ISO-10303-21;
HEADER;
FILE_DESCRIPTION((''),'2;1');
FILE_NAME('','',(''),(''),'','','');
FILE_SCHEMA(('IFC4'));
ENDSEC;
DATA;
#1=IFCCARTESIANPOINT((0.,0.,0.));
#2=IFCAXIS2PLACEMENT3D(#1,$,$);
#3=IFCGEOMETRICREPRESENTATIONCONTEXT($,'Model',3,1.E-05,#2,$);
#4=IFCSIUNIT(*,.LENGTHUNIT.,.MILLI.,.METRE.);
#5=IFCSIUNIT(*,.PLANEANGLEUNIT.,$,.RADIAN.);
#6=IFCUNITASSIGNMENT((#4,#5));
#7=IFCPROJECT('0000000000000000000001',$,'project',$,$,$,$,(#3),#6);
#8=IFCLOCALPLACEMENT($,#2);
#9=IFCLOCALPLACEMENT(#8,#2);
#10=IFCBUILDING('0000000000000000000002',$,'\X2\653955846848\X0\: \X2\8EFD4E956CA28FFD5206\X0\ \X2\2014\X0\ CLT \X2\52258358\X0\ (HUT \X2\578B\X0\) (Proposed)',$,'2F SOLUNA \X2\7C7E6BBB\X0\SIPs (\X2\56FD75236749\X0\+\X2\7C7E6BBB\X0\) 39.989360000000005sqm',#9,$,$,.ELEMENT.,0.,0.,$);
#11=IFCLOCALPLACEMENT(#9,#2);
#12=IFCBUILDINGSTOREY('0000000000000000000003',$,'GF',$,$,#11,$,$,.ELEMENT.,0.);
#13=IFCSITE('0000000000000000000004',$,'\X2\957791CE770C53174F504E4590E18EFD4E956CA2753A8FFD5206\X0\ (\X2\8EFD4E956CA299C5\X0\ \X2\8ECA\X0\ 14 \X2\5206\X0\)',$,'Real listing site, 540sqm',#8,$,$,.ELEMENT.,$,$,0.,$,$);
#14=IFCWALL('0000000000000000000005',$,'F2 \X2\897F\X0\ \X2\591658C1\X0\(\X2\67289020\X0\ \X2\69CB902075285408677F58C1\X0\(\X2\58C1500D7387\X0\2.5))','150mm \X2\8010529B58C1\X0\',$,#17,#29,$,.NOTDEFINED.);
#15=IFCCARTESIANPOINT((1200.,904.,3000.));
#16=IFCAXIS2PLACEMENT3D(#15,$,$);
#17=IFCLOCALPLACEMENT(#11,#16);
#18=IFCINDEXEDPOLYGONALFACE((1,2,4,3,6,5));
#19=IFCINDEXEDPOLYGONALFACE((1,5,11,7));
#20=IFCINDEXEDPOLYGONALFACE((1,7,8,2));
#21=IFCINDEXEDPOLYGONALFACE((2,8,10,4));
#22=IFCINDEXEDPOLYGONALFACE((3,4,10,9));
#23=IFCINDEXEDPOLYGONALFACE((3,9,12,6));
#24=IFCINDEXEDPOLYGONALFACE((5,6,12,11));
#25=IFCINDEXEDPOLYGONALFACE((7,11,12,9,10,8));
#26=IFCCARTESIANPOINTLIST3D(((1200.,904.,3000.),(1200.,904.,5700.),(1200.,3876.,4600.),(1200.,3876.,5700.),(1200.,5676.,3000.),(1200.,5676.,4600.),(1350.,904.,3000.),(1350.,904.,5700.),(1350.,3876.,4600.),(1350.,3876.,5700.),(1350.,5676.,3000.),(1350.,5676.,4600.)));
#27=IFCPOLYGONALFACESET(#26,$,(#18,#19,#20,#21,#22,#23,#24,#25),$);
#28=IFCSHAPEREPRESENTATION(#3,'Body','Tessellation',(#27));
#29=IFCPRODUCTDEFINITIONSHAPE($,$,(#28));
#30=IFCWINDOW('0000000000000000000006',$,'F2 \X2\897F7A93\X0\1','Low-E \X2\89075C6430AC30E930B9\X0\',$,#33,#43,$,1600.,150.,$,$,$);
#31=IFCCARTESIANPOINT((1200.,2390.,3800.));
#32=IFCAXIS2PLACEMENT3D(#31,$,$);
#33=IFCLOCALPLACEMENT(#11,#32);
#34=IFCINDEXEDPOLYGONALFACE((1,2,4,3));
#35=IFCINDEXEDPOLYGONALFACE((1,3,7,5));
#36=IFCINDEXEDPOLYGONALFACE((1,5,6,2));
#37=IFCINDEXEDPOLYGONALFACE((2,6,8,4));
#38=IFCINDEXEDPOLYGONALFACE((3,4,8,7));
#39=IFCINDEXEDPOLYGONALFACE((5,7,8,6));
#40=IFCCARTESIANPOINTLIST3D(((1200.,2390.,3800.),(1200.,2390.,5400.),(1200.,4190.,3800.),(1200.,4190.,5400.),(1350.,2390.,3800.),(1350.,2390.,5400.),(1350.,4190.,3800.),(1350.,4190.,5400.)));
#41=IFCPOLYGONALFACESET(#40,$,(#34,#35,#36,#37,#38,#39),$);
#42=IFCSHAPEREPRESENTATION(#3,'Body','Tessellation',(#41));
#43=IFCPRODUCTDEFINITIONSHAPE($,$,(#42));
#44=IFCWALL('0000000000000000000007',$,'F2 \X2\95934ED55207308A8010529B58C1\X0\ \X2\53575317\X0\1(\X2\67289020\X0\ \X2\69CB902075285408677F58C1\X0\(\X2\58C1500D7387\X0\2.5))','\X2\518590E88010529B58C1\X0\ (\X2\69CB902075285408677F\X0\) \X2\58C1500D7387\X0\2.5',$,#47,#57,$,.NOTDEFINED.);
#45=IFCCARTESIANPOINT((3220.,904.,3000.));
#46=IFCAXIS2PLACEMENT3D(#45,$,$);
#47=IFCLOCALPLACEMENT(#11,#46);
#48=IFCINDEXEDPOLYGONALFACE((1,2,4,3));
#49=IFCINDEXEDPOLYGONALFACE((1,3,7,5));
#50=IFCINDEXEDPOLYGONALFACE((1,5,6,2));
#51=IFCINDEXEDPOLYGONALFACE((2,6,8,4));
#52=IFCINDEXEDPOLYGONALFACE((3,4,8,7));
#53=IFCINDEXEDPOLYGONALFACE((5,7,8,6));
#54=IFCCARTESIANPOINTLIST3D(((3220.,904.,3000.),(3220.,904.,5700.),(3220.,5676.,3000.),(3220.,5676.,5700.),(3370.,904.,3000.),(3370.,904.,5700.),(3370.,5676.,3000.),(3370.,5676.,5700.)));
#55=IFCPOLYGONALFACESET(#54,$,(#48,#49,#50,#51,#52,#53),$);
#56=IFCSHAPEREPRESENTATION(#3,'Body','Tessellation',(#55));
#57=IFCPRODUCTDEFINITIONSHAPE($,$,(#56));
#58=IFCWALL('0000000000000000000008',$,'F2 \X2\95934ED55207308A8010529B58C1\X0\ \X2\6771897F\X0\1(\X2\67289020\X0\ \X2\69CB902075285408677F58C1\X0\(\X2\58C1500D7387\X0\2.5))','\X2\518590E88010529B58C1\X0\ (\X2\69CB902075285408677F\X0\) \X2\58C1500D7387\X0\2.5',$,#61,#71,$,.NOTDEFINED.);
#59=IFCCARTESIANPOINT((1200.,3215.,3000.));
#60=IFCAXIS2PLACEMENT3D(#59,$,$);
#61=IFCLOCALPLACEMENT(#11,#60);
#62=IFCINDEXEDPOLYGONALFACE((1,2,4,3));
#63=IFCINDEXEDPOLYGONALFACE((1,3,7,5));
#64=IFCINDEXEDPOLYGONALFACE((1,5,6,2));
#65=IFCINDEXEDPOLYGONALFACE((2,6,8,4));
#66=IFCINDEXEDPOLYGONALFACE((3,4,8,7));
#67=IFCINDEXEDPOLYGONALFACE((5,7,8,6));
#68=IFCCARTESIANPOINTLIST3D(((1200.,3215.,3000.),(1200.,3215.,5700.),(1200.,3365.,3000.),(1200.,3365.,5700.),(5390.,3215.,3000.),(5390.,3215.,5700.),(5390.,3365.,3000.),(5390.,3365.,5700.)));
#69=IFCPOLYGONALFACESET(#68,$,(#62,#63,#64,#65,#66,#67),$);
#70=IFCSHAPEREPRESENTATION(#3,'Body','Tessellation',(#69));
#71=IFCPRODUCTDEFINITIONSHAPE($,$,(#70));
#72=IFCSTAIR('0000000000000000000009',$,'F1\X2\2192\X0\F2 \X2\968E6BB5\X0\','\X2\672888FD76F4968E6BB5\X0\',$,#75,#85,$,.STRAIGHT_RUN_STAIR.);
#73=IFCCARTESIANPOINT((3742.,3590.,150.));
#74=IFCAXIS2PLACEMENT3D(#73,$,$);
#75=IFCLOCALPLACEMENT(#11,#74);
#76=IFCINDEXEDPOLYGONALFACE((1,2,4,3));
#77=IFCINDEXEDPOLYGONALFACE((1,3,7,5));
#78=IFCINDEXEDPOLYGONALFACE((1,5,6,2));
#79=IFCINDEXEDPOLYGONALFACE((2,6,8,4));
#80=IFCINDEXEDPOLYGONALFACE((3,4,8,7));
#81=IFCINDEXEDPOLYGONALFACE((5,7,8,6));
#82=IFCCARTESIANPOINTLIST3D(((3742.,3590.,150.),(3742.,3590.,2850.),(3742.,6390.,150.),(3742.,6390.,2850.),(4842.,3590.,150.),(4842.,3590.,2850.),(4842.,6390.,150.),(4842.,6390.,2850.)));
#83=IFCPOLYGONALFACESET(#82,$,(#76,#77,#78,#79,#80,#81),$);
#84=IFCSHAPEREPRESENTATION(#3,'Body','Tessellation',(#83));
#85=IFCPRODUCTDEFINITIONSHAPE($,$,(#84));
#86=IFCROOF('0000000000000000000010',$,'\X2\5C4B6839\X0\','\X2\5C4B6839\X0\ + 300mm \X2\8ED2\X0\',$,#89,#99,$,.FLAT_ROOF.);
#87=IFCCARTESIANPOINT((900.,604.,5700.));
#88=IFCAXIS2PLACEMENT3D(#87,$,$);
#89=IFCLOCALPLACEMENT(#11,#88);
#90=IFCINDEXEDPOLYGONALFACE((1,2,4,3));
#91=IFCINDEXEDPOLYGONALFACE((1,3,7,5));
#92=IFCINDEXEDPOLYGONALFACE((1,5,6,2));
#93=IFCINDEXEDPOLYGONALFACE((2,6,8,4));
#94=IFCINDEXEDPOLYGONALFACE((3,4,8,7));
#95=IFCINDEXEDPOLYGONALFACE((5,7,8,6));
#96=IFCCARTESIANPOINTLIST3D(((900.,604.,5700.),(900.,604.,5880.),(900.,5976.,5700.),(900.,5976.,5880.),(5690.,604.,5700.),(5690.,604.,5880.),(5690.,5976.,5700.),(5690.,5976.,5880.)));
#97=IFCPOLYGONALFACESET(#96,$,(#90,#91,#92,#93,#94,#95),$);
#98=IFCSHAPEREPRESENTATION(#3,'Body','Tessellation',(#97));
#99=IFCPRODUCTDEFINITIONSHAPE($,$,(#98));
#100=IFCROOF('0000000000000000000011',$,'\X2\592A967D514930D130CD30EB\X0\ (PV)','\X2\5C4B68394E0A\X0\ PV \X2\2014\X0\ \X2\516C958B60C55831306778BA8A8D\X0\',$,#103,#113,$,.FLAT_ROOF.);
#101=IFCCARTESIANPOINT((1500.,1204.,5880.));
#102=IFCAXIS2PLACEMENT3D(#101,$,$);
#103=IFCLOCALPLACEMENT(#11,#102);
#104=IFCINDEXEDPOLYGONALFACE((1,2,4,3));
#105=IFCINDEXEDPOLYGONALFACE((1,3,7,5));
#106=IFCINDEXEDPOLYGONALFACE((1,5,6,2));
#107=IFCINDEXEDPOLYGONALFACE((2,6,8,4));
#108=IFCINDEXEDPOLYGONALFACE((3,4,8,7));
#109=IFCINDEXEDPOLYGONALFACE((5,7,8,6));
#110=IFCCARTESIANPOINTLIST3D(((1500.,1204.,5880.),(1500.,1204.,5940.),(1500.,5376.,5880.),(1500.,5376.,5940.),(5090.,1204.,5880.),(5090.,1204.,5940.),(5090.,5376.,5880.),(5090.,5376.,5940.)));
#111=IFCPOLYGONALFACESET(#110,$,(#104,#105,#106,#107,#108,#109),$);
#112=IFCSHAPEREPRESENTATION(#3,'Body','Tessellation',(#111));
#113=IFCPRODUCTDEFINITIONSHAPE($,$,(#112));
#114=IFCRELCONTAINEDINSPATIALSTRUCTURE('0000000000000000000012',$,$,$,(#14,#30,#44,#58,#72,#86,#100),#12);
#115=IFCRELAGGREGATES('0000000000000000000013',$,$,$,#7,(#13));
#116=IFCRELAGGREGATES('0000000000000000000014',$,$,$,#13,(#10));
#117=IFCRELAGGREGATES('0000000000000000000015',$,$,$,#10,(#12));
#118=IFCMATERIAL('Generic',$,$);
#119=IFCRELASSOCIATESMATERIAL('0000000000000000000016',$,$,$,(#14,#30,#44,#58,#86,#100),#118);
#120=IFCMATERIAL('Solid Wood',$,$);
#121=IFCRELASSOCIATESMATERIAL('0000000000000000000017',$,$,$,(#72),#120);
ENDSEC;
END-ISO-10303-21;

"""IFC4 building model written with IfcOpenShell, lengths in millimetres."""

from ifc_helpers import new_model, si_unit, frame, frame_2d, origin, place, context, project, spatial, rectangle, extrude, material, element, fill, save


model = new_model("IFC4")

# Units and contexts
model_context = context("Model", 3, precision=1e-05, world=origin())
ifc_project = project(units=[si_unit("LENGTHUNIT", "METRE", prefix="MILLI"), si_unit("PLANEANGLEUNIT", "RADIAN")], contexts=[model_context])

# Site, building, storey
site_placement = place(None, origin())
site = spatial("IfcSite", under=ifc_project, at=site_placement, Name="長野県北佐久郡軽井沢町追分 (軽井沢駅 車 14 分)", ObjectType="Real listing site, 540sqm", CompositionType="ELEMENT", RefElevation=0.0)
building_placement = place(site_placement, origin())
building = spatial("IfcBuilding", under=site, at=building_placement, Name="改善案: 軽井沢追分 — CLT 別荘 (HUT 型) (Proposed)", ObjectType="2F SOLUNA 籾殻SIPs (国産杉+籾殻) 39.989360000000005sqm", CompositionType="ELEMENT", ElevationOfRefHeight=0.0, ElevationOfTerrain=0.0)
storey_placement = place(building_placement, origin())
storey = spatial("IfcBuildingStorey", under=building, at=storey_placement, Name="GF", CompositionType="ELEMENT", Elevation=0.0)

# Shared definitions
ifc_material_1 = material(Name="Generic")

# Shared definitions
ifc_material_2 = material(Name="Solid Wood")

# Wall, opening, window
wall_1_placement = place(storey_placement, frame((1200.0, 904.0, 3000.0)))
wall_1 = element("IfcWall", 1, at=wall_1_placement, inside=storey, material=ifc_material_1, Name="F2 西 外壁(木造 構造用合板壁(壁倍率2.5))", Description="150mm 耐力壁", PredefinedType="NOTDEFINED", context=model_context, shape_type="SweptSolid", body=[
    extrude(rectangle(XDim=150.0, YDim=4772.0, at=frame_2d((75.0, 2386.0))), frame((1200.0, 904.0, 3000.0)), (0.0, 0.0, 1.0), 2700.0),
])
opening_1_placement = place(storey_placement, frame((1200.0, 2390.0, 3800.0)))
opening_1 = element("IfcOpeningElement", 2, at=opening_1_placement, cuts=wall_1, PredefinedType="NOTDEFINED", context=model_context, shape_type="SweptSolid", body=[
    extrude(rectangle(XDim=150.0, YDim=1800.0, at=frame_2d((75.0, 900.0))), frame((1200.0, 2390.0, 3800.0)), (0.0, 0.0, 1.0), 1600.0),
])
window_1_placement = place(storey_placement, frame((1200.0, 2390.0, 3800.0)))
window_1 = element("IfcWindow", 3, at=window_1_placement, inside=storey, material=ifc_material_1, Name="F2 西窓1", Description="Low-E 複層ガラス", OverallHeight=1600.0, OverallWidth=150.0, context=model_context, shape_type="SweptSolid", body=[
    extrude(rectangle(XDim=150.0, YDim=1800.0, at=frame_2d((75.0, 900.0))), frame((1200.0, 2390.0, 3800.0)), (0.0, 0.0, 1.0), 1600.0),
])
fill(opening_1, window_1)

# Walls
wall_2_placement = place(storey_placement, frame((3220.0, 904.0, 3000.0)))
element("IfcWall", 4, at=wall_2_placement, inside=storey, material=ifc_material_1, Name="F2 間仕切り耐力壁 南北1(木造 構造用合板壁(壁倍率2.5))", Description="内部耐力壁 (構造用合板) 壁倍率2.5", PredefinedType="NOTDEFINED", context=model_context, shape_type="SweptSolid", body=[
    extrude(rectangle(XDim=150.0, YDim=4772.0, at=frame_2d((75.0, 2386.0))), frame((3220.0, 904.0, 3000.0)), (0.0, 0.0, 1.0), 2700.0),
])
wall_3_placement = place(storey_placement, frame((1200.0, 3215.0, 3000.0)))
element("IfcWall", 5, at=wall_3_placement, inside=storey, material=ifc_material_1, Name="F2 間仕切り耐力壁 東西1(木造 構造用合板壁(壁倍率2.5))", Description="内部耐力壁 (構造用合板) 壁倍率2.5", PredefinedType="NOTDEFINED", context=model_context, shape_type="SweptSolid", body=[
    extrude(rectangle(XDim=4190.0, YDim=150.0, at=frame_2d((2095.0, 75.0))), frame((1200.0, 3215.0, 3000.0)), (0.0, 0.0, 1.0), 2700.0),
])

# Stair
stair_placement = place(storey_placement, frame((3742.0, 3590.0, 150.0)))
element("IfcStair", 6, at=stair_placement, inside=storey, material=ifc_material_2, Name="F1→F2 階段", Description="木製直階段", PredefinedType="STRAIGHT_RUN_STAIR", context=model_context, shape_type="SweptSolid", body=[
    extrude(rectangle(XDim=1100.0, YDim=2800.0, at=frame_2d((550.0, 1400.0))), frame((3742.0, 3590.0, 150.0)), (0.0, 0.0, 1.0), 2700.0),
])

# Roofs
roof_1_placement = place(storey_placement, frame((900.0, 604.0, 5700.0)))
element("IfcRoof", 7, at=roof_1_placement, inside=storey, material=ifc_material_1, Name="屋根", Description="屋根 + 300mm 軒", PredefinedType="FLAT_ROOF", context=model_context, shape_type="SweptSolid", body=[
    extrude(rectangle(XDim=4790.0, YDim=5372.0, at=frame_2d((2395.0, 2686.0))), frame((900.0, 604.0, 5700.0)), (0.0, 0.0, 1.0), 180.0),
])
roof_2_placement = place(storey_placement, frame((1500.0, 1204.0, 5880.0)))
element("IfcRoof", 8, at=roof_2_placement, inside=storey, material=ifc_material_1, Name="太陽光パネル (PV)", Description="屋根上 PV — 公開情報で確認", PredefinedType="FLAT_ROOF", context=model_context, shape_type="SweptSolid", body=[
    extrude(rectangle(XDim=3590.0, YDim=4172.0, at=frame_2d((1795.0, 2086.0))), frame((1500.0, 1204.0, 5880.0)), (0.0, 0.0, 1.0), 60.0),
])

save(model, "model.ifc")
